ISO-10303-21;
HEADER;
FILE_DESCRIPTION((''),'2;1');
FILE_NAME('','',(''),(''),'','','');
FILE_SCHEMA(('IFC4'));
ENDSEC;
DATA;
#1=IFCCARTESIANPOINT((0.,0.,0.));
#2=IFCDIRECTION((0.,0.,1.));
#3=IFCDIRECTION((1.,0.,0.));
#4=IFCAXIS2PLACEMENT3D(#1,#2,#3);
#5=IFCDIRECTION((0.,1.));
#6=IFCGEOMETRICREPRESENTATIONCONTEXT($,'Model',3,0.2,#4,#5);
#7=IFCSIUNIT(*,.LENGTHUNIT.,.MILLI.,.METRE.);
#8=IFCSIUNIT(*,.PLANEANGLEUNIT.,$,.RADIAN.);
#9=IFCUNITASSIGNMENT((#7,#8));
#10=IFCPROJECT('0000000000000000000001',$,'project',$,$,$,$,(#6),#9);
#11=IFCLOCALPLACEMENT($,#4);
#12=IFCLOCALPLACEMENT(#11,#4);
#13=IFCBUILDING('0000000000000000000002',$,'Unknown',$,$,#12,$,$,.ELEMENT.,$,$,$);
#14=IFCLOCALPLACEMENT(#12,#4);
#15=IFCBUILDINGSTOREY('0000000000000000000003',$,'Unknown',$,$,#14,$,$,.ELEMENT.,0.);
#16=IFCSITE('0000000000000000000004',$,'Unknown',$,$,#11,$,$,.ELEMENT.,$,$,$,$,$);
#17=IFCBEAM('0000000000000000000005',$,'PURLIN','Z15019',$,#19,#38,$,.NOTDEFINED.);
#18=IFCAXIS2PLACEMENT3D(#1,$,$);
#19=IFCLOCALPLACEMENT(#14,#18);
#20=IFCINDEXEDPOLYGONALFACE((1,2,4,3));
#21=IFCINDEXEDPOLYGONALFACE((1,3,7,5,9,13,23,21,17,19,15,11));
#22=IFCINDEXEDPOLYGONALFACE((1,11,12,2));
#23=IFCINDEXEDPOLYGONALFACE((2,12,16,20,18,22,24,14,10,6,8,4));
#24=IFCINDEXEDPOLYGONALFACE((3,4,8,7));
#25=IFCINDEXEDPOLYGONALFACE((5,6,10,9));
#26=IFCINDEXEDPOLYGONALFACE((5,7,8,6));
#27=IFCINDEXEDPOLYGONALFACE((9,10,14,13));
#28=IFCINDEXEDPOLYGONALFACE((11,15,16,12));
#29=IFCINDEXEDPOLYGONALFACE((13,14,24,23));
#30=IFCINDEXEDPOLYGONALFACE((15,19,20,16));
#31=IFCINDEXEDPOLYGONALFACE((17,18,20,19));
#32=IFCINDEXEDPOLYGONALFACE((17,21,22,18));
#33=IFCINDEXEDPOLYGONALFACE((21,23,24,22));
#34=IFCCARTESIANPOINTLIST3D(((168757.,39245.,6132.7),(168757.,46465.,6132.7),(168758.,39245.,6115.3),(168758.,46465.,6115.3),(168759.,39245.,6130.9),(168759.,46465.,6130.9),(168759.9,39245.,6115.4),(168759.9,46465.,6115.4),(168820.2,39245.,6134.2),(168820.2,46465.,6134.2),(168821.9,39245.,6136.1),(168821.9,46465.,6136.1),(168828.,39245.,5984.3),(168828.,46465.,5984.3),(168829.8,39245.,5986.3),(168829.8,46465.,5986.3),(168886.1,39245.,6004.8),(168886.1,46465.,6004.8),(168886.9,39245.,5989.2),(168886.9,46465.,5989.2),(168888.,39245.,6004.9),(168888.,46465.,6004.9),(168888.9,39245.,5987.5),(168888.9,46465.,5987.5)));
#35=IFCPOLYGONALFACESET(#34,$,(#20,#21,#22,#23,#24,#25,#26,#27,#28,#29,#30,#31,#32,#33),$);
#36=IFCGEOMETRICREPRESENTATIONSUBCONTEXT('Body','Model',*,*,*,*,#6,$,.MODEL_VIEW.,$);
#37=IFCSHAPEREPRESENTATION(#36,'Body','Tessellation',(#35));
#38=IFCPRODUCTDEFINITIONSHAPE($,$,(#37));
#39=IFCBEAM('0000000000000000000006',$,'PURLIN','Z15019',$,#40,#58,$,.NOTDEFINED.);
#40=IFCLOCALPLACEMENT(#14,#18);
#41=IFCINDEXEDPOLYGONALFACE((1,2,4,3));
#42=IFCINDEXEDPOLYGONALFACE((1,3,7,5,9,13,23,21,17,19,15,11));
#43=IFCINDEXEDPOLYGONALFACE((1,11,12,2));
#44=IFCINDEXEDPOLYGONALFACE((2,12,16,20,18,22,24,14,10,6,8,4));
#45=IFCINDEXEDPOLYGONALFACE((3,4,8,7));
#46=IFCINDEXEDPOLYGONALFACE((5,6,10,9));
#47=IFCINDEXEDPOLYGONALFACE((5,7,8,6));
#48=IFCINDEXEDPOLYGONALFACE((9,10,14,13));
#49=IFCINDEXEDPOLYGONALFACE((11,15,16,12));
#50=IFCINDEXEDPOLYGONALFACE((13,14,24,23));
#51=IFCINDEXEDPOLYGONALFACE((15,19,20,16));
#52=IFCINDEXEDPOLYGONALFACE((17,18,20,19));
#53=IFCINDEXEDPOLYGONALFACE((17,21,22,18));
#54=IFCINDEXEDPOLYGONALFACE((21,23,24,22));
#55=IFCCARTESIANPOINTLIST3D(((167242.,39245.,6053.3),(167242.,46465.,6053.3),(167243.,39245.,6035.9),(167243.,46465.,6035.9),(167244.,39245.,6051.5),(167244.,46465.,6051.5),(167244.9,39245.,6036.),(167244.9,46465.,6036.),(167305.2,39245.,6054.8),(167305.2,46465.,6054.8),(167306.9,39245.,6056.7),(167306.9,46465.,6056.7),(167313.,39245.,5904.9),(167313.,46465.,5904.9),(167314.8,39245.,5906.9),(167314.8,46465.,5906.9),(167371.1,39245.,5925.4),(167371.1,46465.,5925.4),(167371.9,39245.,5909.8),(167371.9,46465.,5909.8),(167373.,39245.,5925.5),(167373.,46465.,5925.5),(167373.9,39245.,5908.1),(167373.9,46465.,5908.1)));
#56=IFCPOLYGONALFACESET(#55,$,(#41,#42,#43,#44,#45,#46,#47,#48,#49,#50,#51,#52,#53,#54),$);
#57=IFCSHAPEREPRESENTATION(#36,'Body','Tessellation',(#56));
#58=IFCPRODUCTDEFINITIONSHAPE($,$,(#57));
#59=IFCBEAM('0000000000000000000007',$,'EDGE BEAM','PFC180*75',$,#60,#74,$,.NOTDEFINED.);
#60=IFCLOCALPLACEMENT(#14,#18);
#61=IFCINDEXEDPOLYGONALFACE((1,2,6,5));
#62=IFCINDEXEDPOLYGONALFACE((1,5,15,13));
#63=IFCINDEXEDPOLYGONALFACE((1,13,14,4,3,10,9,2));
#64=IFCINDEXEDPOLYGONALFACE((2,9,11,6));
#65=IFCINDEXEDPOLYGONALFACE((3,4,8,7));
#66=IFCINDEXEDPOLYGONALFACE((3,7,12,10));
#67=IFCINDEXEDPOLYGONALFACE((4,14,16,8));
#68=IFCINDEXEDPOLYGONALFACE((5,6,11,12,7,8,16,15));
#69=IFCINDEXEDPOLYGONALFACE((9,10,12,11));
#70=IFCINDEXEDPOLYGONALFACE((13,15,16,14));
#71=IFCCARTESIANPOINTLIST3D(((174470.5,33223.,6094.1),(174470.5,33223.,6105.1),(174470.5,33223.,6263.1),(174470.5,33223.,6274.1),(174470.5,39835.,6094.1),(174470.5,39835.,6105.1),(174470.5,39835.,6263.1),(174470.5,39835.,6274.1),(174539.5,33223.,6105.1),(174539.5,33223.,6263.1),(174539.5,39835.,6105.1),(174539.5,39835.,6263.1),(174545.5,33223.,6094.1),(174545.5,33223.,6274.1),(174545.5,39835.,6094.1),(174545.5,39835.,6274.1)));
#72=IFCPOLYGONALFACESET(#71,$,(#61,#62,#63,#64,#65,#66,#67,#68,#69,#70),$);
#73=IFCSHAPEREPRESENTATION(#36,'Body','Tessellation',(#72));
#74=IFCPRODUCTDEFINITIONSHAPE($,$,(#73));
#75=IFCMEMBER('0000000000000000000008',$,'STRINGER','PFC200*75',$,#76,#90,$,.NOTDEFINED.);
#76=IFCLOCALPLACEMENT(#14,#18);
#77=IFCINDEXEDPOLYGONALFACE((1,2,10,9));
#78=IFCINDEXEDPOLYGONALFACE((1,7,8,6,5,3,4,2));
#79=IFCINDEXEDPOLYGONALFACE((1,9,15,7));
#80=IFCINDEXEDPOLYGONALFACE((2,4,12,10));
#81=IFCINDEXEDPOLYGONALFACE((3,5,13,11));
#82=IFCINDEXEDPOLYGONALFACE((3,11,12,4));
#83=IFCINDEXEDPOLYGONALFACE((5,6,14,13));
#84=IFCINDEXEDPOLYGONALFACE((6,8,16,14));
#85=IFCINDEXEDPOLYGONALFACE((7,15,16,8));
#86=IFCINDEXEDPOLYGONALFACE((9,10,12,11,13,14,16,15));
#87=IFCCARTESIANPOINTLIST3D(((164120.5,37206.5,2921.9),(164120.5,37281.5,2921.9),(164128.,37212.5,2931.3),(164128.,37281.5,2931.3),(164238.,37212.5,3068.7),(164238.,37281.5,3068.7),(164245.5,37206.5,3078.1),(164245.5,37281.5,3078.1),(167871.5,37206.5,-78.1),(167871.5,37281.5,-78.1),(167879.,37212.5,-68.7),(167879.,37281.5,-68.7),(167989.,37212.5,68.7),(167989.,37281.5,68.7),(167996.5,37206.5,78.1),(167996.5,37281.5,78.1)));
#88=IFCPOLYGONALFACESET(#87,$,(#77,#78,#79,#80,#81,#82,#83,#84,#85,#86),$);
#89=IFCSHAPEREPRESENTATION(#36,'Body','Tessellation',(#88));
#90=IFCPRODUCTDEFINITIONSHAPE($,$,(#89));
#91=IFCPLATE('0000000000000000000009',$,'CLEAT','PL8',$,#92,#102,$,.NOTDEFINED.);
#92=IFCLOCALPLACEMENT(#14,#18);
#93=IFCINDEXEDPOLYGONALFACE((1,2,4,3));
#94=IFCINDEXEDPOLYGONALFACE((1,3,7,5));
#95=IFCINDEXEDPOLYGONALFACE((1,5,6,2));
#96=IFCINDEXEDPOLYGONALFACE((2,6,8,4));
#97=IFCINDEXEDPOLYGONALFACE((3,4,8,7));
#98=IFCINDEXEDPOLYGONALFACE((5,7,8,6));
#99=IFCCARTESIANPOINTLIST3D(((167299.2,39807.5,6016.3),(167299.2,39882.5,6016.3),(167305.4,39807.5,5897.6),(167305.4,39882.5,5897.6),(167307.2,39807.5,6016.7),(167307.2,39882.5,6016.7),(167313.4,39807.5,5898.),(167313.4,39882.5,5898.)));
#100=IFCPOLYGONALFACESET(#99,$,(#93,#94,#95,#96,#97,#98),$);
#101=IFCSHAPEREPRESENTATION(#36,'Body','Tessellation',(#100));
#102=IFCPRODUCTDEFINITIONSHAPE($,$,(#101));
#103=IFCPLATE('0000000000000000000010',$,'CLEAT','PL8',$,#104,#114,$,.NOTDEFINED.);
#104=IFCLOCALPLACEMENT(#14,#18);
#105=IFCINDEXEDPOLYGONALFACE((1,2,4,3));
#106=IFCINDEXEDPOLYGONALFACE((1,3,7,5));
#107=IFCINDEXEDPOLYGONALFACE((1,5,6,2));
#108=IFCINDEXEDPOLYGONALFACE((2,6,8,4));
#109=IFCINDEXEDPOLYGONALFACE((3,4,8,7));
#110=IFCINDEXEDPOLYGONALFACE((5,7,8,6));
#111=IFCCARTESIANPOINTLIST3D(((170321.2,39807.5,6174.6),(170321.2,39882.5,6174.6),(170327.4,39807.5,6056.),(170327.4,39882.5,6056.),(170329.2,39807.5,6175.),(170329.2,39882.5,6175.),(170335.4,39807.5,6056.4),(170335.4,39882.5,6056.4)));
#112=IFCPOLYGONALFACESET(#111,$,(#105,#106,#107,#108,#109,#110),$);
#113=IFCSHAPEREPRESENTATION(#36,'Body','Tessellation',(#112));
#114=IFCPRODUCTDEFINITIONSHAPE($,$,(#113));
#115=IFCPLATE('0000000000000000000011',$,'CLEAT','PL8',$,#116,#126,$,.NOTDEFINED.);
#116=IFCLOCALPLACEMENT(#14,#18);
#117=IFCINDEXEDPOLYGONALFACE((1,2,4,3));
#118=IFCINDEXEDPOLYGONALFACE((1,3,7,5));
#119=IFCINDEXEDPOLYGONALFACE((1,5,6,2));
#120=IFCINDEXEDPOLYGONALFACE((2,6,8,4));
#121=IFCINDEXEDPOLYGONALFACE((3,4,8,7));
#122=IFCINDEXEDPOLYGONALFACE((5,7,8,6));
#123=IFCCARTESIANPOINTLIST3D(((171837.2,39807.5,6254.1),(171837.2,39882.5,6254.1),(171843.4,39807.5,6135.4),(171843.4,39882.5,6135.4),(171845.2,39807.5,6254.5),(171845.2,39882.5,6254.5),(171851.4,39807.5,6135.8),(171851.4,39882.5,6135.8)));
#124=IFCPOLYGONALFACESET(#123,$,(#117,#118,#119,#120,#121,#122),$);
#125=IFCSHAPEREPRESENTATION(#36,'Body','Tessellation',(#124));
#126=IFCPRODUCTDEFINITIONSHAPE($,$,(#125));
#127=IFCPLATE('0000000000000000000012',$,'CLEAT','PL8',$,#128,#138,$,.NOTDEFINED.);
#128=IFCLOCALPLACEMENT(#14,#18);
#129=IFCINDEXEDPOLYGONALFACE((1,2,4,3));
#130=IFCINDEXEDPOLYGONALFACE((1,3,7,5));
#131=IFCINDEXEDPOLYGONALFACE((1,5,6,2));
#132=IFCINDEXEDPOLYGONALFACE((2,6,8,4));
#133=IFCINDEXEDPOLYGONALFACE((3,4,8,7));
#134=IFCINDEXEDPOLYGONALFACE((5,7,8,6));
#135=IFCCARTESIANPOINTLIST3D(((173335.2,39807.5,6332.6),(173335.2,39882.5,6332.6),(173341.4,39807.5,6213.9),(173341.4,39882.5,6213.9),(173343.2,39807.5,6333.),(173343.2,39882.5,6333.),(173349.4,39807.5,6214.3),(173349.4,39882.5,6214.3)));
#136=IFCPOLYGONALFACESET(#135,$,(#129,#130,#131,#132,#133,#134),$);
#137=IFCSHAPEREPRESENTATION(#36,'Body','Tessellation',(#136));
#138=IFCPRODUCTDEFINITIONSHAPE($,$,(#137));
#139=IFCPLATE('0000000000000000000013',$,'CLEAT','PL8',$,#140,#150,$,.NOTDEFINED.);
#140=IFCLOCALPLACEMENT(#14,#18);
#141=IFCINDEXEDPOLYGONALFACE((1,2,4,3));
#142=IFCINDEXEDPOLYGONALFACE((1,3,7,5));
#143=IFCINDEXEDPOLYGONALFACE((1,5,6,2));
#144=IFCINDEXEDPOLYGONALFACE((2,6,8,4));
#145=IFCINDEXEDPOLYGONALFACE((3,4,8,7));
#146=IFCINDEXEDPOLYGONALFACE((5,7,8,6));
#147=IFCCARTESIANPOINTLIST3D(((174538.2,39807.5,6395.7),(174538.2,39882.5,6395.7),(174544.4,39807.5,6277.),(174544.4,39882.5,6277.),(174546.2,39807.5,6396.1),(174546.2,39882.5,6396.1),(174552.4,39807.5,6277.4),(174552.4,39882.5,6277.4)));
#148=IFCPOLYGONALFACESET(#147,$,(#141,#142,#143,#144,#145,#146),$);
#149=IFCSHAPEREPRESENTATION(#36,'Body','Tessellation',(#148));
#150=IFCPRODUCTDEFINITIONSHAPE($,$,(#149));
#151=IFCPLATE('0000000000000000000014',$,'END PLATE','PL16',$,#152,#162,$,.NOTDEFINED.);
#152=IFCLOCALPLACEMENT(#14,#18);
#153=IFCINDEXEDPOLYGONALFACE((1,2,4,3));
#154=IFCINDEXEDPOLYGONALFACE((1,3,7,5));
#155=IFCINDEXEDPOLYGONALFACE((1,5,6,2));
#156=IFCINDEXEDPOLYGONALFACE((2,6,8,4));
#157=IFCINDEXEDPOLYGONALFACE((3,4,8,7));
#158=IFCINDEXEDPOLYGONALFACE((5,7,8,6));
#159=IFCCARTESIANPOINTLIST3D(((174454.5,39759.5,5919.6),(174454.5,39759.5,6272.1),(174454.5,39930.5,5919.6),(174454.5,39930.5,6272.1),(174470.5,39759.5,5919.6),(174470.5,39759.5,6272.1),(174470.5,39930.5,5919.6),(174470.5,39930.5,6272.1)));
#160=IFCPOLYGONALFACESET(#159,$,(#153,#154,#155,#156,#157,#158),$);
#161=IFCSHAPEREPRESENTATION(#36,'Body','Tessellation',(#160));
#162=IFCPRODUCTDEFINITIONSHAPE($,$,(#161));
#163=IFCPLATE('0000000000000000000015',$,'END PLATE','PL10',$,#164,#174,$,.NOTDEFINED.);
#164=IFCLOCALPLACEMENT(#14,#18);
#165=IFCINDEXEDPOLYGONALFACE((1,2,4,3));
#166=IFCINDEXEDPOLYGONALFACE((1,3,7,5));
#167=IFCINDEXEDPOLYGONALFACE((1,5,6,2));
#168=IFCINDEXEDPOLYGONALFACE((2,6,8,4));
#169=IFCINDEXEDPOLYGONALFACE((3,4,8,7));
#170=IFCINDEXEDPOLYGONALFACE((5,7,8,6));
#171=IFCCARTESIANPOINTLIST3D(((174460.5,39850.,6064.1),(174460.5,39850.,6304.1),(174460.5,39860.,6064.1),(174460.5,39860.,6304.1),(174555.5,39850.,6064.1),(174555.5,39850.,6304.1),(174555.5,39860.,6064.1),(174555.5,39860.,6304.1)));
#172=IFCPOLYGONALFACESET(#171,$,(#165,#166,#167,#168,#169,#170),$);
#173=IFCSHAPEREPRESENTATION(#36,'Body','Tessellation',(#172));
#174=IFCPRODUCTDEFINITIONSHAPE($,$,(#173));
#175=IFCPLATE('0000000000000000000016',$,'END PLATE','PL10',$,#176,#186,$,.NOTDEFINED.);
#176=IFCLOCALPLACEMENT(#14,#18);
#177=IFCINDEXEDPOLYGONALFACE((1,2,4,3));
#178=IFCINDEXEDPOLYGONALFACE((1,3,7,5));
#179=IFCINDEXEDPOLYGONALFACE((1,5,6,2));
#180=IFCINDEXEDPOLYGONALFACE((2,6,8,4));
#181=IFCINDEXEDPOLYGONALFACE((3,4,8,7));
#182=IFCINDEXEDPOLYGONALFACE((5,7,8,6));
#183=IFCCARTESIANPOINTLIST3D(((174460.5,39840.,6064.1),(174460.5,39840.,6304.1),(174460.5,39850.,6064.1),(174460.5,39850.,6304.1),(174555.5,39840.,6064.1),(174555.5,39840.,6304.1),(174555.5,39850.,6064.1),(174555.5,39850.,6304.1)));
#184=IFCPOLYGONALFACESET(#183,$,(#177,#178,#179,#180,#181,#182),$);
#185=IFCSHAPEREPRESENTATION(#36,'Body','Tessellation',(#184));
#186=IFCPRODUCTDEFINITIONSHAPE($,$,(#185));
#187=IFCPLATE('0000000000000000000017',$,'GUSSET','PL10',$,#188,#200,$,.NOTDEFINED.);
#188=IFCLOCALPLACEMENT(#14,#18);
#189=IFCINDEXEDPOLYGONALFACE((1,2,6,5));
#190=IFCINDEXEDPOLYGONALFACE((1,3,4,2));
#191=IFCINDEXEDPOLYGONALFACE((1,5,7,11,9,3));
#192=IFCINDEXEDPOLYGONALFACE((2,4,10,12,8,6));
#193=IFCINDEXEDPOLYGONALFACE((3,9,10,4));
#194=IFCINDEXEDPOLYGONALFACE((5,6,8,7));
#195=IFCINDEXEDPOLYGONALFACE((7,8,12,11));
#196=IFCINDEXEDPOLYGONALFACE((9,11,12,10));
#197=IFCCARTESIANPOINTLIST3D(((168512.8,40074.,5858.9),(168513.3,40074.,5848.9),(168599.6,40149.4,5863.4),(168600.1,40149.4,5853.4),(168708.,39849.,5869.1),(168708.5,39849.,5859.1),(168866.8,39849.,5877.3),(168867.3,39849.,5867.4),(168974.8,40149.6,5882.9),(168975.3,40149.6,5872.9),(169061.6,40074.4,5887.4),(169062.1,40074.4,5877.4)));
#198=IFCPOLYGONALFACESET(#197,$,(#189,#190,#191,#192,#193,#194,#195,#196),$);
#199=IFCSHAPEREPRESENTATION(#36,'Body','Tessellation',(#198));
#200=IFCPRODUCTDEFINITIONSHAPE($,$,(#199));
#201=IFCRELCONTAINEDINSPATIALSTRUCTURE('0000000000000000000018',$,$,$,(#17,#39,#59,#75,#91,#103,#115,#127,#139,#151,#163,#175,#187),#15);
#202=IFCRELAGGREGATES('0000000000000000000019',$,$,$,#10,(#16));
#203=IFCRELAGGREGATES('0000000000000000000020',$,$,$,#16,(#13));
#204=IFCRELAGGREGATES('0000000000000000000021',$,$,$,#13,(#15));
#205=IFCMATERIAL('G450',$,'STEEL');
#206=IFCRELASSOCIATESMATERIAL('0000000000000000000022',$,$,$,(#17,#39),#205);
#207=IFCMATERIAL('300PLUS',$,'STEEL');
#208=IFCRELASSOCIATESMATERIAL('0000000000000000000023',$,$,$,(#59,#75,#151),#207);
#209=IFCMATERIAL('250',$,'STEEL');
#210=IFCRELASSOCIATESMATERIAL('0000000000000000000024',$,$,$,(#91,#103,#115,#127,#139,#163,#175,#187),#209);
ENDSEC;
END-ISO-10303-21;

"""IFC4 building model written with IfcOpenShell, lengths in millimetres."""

from ifc_helpers import new_model, si_unit, direction, frame, origin_with_axes, place, context, subcontext, project, spatial, line, indexed_curve, outline, extrude, material, element, save


model = new_model("IFC4")

# Units and contexts
model_context = context("Model", 3, precision=0.2, world=origin_with_axes(), true_north=direction((0.0, 1.0)))
body_context = subcontext(model_context, "Body", "Model", "MODEL_VIEW")
ifc_project = project(units=[si_unit("LENGTHUNIT", "METRE", prefix="MILLI"), si_unit("PLANEANGLEUNIT", "RADIAN")], contexts=[model_context])

# Site, building, storey
site_placement = place(None, origin_with_axes())
site = spatial("IfcSite", under=ifc_project, at=site_placement, Name="Unknown", CompositionType="ELEMENT")
building_placement = place(site_placement, origin_with_axes())
building = spatial("IfcBuilding", under=site, at=building_placement, Name="Unknown", CompositionType="ELEMENT")
storey_placement = place(building_placement, origin_with_axes())
storey = spatial("IfcBuildingStorey", under=building, at=storey_placement, Name="Unknown", CompositionType="ELEMENT", Elevation=0.0)

# Beams
ifc_material_1 = material(Name="G450", Category="STEEL")
for number, where, z_axis, x_axis, name in (
    (1, (168825.0, 39245.0, 6060.2), (0.99863, 0.0, 0.052336), (0.0, 1.0, 0.0), "PURLIN"),
    (2, (167310.0, 39245.0, 5980.8), (0.99863, 0.0, 0.052336), (0.0, 1.0, 0.0), "PURLIN"),
):
    element("IfcBeam", number, at=place(storey_placement, frame(where, z_axis=z_axis, x_axis=x_axis)), inside=storey, material=ifc_material_1, Name=name, Description="Z15019", PredefinedType="NOTDEFINED", context=body_context, shape_type="SolidModel", body=[
        extrude(outline(indexed_curve([(60.0, -76.0), (60.0, -58.5), (58.1, -58.5), (58.1, -74.1), (0.9, -74.1), (0.9, 76.0), (-64.0, 76.0), (-64.0, 58.5), (-62.1, 58.5), (-62.1, 74.1), (-0.9, 74.1), (-0.9, -76.0)], segments=[line(1, 2, 3, 4, 5, 6, 7, 8, 9, 10, 11, 12, 1)])), frame((0.0, 0.0, 0.0), z_axis=(-1.0, 0.0, 0.0), x_axis=(0.0, 0.0, 1.0)), (0.0, 0.0, -1.0), 7220.0),
    ])
ifc_material_2 = material(Name="300PLUS", Category="STEEL")
beam_1_placement = place(storey_placement, frame((174508.0, 39835.0, 6184.1), z_axis=(-1.0, 0.0, 0.0), x_axis=(0.0, -1.0, 0.0)))
element("IfcBeam", 3, at=beam_1_placement, inside=storey, material=ifc_material_2, Name="EDGE BEAM", Description="PFC180*75", PredefinedType="NOTDEFINED", context=body_context, shape_type="SolidModel", body=[
    extrude(outline(indexed_curve([(-37.5, -90.0), (37.5, -90.0), (37.5, -79.0), (-31.5, -79.0), (-31.5, 79.0), (37.5, 79.0), (37.5, 90.0), (-37.5, 90.0)], segments=[line(1, 2, 3, 4, 5, 6, 7, 8, 1)])), frame((0.0, 0.0, 0.0), z_axis=(-1.0, 0.0, 0.0), x_axis=(0.0, 0.0, 1.0)), (0.0, 0.0, -1.0), 6612.0),
])

# Member
member_placement = place(storey_placement, frame((167934.0, 37244.0, 0.0), z_axis=(0.0, 1.0, 0.0), x_axis=(-0.78095, 0.0, 0.624593)))
element("IfcMember", 4, at=member_placement, inside=storey, material=ifc_material_2, Name="STRINGER", Description="PFC200*75", PredefinedType="NOTDEFINED", context=body_context, shape_type="SolidModel", body=[
    extrude(outline(indexed_curve([(-37.5, -100.0), (37.5, -100.0), (37.5, -88.0), (-31.5, -88.0), (-31.5, 88.0), (37.5, 88.0), (37.5, 100.0), (-37.5, 100.0)], segments=[line(1, 2, 3, 4, 5, 6, 7, 8, 1)])), frame((0.0, 0.0, 0.0), z_axis=(-1.0, 0.0, 0.0), x_axis=(0.0, 0.0, 1.0)), (0.0, 0.0, -1.0), 4803.1),
])

# Plates
ifc_material_3 = material(Name="250", Category="STEEL")
plate_1_placement = place(storey_placement, frame((167309.4, 39807.5, 5897.8), z_axis=(0.998639, 0.0, 0.052161), x_axis=(0.0, 1.0, 0.0)))
element("IfcPlate", 5, at=plate_1_placement, inside=storey, material=ifc_material_3, Name="CLEAT", Description="PL8", PredefinedType="NOTDEFINED", context=body_context, shape_type="SolidModel", body=[
    extrude(outline(indexed_curve([(0.0, 0.0), (75.0, 0.0), (75.0, 118.9), (0.0, 118.9)], segments=[line(1, 2, 3, 4, 1)])), frame((0.0, 0.0, 4.0), z_axis=(0.0, 0.0, 1.0), x_axis=(1.0, 0.0, 0.0)), (0.0, 0.0, -1.0), 8.0),
])
plate_2_placement = place(storey_placement, frame((170331.4, 39807.5, 6056.2), z_axis=(0.998636, 0.0, 0.052205), x_axis=(0.0, 1.0, 0.0)))
element("IfcPlate", 6, at=plate_2_placement, inside=storey, material=ifc_material_3, Name="CLEAT", Description="PL8", PredefinedType="NOTDEFINED", context=body_context, shape_type="SolidModel", body=[
    extrude(outline(indexed_curve([(0.0, 0.0), (75.0, 0.0), (75.0, 118.8), (0.0, 118.8)], segments=[line(1, 2, 3, 4, 1)])), frame((0.0, 0.0, 4.0), z_axis=(0.0, 0.0, 1.0), x_axis=(1.0, 0.0, 0.0)), (0.0, 0.0, -1.0), 8.0),
])
for number, where, z_axis, x_axis, name in (
    (7, (171847.4, 39807.5, 6135.6), (0.998639, 0.0, 0.052161), (0.0, 1.0, 0.0), "CLEAT"),
    (8, (173345.4, 39807.5, 6214.1), (0.998639, 0.0, 0.052161), (0.0, 1.0, 0.0), "CLEAT"),
    (9, (174548.4, 39807.5, 6277.2), (0.998639, 0.0, 0.052161), (0.0, 1.0, 0.0), "CLEAT"),
):
    element("IfcPlate", number, at=place(storey_placement, frame(where, z_axis=z_axis, x_axis=x_axis)), inside=storey, material=ifc_material_3, Name=name, Description="PL8", PredefinedType="NOTDEFINED", context=body_context, shape_type="SolidModel", body=[
        extrude(outline(indexed_curve([(0.0, 0.0), (75.0, 0.0), (75.0, 118.9), (0.0, 118.9)], segments=[line(1, 2, 3, 4, 1)])), frame((0.0, 0.0, 4.0), z_axis=(0.0, 0.0, 1.0), x_axis=(1.0, 0.0, 0.0)), (0.0, 0.0, -1.0), 8.0),
    ])
plate_3_placement = place(storey_placement, frame((174462.5, 39759.5, 6272.1), z_axis=(-1.0, 0.0, 0.0), x_axis=(0.0, 1.0, 0.0)))
element("IfcPlate", 10, at=plate_3_placement, inside=storey, material=ifc_material_2, Name="END PLATE", Description="PL16", PredefinedType="NOTDEFINED", context=body_context, shape_type="SolidModel", body=[
    extrude(outline(indexed_curve([(0.0, 0.0), (171.0, 0.0), (171.0, 352.5), (0.0, 352.5)], segments=[line(1, 2, 3, 4, 1)])), frame((0.0, 0.0, 8.0), z_axis=(0.0, 0.0, 1.0), x_axis=(1.0, 0.0, 0.0)), (0.0, 0.0, -1.0), 16.0),
])
for number, where, z_axis, x_axis, name in (
    (11, (174555.5, 39855.0, 6064.1), (0.0, 1.0, 0.0), (-1.0, 0.0, 0.0), "END PLATE"),
    (12, (174555.5, 39845.0, 6064.1), (0.0, 1.0, 0.0), (-1.0, 0.0, 0.0), "END PLATE"),
):
    element("IfcPlate", number, at=place(storey_placement, frame(where, z_axis=z_axis, x_axis=x_axis)), inside=storey, material=ifc_material_3, Name=name, Description="PL10", PredefinedType="NOTDEFINED", context=body_context, shape_type="SolidModel", body=[
        extrude(outline(indexed_curve([(0.0, 0.0), (95.0, 0.0), (95.0, 240.0), (0.0, 240.0)], segments=[line(1, 2, 3, 4, 1)])), frame((0.0, 0.0, 5.0), z_axis=(0.0, 0.0, 1.0), x_axis=(1.0, 0.0, 0.0)), (0.0, 0.0, -1.0), 10.0),
    ])
plate_4_placement = place(storey_placement, frame((168513.0, 40074.0, 5853.9), z_axis=(-0.05195, 0.000203, 0.99865), x_axis=(0.65493, -0.754914, 0.034223)))
element("IfcPlate", 13, at=plate_4_placement, inside=storey, material=ifc_material_3, Name="GUSSET", Description="PL10", PredefinedType="NOTDEFINED", context=body_context, shape_type="SolidModel", body=[
    extrude(outline(indexed_curve([(0.0, 0.0), (298.0, 0.0), (402.3, 120.0), (360.1, 415.1), (246.3, 398.8), (0.1, 115.1)], segments=[line(1, 2, 3, 4, 5, 6, 1)])), frame((0.0, 0.0, 5.0), z_axis=(0.0, 0.0, 1.0), x_axis=(1.0, 0.0, 0.0)), (0.0, 0.0, -1.0), 10.0),
])

save(model, "model.ifc")
